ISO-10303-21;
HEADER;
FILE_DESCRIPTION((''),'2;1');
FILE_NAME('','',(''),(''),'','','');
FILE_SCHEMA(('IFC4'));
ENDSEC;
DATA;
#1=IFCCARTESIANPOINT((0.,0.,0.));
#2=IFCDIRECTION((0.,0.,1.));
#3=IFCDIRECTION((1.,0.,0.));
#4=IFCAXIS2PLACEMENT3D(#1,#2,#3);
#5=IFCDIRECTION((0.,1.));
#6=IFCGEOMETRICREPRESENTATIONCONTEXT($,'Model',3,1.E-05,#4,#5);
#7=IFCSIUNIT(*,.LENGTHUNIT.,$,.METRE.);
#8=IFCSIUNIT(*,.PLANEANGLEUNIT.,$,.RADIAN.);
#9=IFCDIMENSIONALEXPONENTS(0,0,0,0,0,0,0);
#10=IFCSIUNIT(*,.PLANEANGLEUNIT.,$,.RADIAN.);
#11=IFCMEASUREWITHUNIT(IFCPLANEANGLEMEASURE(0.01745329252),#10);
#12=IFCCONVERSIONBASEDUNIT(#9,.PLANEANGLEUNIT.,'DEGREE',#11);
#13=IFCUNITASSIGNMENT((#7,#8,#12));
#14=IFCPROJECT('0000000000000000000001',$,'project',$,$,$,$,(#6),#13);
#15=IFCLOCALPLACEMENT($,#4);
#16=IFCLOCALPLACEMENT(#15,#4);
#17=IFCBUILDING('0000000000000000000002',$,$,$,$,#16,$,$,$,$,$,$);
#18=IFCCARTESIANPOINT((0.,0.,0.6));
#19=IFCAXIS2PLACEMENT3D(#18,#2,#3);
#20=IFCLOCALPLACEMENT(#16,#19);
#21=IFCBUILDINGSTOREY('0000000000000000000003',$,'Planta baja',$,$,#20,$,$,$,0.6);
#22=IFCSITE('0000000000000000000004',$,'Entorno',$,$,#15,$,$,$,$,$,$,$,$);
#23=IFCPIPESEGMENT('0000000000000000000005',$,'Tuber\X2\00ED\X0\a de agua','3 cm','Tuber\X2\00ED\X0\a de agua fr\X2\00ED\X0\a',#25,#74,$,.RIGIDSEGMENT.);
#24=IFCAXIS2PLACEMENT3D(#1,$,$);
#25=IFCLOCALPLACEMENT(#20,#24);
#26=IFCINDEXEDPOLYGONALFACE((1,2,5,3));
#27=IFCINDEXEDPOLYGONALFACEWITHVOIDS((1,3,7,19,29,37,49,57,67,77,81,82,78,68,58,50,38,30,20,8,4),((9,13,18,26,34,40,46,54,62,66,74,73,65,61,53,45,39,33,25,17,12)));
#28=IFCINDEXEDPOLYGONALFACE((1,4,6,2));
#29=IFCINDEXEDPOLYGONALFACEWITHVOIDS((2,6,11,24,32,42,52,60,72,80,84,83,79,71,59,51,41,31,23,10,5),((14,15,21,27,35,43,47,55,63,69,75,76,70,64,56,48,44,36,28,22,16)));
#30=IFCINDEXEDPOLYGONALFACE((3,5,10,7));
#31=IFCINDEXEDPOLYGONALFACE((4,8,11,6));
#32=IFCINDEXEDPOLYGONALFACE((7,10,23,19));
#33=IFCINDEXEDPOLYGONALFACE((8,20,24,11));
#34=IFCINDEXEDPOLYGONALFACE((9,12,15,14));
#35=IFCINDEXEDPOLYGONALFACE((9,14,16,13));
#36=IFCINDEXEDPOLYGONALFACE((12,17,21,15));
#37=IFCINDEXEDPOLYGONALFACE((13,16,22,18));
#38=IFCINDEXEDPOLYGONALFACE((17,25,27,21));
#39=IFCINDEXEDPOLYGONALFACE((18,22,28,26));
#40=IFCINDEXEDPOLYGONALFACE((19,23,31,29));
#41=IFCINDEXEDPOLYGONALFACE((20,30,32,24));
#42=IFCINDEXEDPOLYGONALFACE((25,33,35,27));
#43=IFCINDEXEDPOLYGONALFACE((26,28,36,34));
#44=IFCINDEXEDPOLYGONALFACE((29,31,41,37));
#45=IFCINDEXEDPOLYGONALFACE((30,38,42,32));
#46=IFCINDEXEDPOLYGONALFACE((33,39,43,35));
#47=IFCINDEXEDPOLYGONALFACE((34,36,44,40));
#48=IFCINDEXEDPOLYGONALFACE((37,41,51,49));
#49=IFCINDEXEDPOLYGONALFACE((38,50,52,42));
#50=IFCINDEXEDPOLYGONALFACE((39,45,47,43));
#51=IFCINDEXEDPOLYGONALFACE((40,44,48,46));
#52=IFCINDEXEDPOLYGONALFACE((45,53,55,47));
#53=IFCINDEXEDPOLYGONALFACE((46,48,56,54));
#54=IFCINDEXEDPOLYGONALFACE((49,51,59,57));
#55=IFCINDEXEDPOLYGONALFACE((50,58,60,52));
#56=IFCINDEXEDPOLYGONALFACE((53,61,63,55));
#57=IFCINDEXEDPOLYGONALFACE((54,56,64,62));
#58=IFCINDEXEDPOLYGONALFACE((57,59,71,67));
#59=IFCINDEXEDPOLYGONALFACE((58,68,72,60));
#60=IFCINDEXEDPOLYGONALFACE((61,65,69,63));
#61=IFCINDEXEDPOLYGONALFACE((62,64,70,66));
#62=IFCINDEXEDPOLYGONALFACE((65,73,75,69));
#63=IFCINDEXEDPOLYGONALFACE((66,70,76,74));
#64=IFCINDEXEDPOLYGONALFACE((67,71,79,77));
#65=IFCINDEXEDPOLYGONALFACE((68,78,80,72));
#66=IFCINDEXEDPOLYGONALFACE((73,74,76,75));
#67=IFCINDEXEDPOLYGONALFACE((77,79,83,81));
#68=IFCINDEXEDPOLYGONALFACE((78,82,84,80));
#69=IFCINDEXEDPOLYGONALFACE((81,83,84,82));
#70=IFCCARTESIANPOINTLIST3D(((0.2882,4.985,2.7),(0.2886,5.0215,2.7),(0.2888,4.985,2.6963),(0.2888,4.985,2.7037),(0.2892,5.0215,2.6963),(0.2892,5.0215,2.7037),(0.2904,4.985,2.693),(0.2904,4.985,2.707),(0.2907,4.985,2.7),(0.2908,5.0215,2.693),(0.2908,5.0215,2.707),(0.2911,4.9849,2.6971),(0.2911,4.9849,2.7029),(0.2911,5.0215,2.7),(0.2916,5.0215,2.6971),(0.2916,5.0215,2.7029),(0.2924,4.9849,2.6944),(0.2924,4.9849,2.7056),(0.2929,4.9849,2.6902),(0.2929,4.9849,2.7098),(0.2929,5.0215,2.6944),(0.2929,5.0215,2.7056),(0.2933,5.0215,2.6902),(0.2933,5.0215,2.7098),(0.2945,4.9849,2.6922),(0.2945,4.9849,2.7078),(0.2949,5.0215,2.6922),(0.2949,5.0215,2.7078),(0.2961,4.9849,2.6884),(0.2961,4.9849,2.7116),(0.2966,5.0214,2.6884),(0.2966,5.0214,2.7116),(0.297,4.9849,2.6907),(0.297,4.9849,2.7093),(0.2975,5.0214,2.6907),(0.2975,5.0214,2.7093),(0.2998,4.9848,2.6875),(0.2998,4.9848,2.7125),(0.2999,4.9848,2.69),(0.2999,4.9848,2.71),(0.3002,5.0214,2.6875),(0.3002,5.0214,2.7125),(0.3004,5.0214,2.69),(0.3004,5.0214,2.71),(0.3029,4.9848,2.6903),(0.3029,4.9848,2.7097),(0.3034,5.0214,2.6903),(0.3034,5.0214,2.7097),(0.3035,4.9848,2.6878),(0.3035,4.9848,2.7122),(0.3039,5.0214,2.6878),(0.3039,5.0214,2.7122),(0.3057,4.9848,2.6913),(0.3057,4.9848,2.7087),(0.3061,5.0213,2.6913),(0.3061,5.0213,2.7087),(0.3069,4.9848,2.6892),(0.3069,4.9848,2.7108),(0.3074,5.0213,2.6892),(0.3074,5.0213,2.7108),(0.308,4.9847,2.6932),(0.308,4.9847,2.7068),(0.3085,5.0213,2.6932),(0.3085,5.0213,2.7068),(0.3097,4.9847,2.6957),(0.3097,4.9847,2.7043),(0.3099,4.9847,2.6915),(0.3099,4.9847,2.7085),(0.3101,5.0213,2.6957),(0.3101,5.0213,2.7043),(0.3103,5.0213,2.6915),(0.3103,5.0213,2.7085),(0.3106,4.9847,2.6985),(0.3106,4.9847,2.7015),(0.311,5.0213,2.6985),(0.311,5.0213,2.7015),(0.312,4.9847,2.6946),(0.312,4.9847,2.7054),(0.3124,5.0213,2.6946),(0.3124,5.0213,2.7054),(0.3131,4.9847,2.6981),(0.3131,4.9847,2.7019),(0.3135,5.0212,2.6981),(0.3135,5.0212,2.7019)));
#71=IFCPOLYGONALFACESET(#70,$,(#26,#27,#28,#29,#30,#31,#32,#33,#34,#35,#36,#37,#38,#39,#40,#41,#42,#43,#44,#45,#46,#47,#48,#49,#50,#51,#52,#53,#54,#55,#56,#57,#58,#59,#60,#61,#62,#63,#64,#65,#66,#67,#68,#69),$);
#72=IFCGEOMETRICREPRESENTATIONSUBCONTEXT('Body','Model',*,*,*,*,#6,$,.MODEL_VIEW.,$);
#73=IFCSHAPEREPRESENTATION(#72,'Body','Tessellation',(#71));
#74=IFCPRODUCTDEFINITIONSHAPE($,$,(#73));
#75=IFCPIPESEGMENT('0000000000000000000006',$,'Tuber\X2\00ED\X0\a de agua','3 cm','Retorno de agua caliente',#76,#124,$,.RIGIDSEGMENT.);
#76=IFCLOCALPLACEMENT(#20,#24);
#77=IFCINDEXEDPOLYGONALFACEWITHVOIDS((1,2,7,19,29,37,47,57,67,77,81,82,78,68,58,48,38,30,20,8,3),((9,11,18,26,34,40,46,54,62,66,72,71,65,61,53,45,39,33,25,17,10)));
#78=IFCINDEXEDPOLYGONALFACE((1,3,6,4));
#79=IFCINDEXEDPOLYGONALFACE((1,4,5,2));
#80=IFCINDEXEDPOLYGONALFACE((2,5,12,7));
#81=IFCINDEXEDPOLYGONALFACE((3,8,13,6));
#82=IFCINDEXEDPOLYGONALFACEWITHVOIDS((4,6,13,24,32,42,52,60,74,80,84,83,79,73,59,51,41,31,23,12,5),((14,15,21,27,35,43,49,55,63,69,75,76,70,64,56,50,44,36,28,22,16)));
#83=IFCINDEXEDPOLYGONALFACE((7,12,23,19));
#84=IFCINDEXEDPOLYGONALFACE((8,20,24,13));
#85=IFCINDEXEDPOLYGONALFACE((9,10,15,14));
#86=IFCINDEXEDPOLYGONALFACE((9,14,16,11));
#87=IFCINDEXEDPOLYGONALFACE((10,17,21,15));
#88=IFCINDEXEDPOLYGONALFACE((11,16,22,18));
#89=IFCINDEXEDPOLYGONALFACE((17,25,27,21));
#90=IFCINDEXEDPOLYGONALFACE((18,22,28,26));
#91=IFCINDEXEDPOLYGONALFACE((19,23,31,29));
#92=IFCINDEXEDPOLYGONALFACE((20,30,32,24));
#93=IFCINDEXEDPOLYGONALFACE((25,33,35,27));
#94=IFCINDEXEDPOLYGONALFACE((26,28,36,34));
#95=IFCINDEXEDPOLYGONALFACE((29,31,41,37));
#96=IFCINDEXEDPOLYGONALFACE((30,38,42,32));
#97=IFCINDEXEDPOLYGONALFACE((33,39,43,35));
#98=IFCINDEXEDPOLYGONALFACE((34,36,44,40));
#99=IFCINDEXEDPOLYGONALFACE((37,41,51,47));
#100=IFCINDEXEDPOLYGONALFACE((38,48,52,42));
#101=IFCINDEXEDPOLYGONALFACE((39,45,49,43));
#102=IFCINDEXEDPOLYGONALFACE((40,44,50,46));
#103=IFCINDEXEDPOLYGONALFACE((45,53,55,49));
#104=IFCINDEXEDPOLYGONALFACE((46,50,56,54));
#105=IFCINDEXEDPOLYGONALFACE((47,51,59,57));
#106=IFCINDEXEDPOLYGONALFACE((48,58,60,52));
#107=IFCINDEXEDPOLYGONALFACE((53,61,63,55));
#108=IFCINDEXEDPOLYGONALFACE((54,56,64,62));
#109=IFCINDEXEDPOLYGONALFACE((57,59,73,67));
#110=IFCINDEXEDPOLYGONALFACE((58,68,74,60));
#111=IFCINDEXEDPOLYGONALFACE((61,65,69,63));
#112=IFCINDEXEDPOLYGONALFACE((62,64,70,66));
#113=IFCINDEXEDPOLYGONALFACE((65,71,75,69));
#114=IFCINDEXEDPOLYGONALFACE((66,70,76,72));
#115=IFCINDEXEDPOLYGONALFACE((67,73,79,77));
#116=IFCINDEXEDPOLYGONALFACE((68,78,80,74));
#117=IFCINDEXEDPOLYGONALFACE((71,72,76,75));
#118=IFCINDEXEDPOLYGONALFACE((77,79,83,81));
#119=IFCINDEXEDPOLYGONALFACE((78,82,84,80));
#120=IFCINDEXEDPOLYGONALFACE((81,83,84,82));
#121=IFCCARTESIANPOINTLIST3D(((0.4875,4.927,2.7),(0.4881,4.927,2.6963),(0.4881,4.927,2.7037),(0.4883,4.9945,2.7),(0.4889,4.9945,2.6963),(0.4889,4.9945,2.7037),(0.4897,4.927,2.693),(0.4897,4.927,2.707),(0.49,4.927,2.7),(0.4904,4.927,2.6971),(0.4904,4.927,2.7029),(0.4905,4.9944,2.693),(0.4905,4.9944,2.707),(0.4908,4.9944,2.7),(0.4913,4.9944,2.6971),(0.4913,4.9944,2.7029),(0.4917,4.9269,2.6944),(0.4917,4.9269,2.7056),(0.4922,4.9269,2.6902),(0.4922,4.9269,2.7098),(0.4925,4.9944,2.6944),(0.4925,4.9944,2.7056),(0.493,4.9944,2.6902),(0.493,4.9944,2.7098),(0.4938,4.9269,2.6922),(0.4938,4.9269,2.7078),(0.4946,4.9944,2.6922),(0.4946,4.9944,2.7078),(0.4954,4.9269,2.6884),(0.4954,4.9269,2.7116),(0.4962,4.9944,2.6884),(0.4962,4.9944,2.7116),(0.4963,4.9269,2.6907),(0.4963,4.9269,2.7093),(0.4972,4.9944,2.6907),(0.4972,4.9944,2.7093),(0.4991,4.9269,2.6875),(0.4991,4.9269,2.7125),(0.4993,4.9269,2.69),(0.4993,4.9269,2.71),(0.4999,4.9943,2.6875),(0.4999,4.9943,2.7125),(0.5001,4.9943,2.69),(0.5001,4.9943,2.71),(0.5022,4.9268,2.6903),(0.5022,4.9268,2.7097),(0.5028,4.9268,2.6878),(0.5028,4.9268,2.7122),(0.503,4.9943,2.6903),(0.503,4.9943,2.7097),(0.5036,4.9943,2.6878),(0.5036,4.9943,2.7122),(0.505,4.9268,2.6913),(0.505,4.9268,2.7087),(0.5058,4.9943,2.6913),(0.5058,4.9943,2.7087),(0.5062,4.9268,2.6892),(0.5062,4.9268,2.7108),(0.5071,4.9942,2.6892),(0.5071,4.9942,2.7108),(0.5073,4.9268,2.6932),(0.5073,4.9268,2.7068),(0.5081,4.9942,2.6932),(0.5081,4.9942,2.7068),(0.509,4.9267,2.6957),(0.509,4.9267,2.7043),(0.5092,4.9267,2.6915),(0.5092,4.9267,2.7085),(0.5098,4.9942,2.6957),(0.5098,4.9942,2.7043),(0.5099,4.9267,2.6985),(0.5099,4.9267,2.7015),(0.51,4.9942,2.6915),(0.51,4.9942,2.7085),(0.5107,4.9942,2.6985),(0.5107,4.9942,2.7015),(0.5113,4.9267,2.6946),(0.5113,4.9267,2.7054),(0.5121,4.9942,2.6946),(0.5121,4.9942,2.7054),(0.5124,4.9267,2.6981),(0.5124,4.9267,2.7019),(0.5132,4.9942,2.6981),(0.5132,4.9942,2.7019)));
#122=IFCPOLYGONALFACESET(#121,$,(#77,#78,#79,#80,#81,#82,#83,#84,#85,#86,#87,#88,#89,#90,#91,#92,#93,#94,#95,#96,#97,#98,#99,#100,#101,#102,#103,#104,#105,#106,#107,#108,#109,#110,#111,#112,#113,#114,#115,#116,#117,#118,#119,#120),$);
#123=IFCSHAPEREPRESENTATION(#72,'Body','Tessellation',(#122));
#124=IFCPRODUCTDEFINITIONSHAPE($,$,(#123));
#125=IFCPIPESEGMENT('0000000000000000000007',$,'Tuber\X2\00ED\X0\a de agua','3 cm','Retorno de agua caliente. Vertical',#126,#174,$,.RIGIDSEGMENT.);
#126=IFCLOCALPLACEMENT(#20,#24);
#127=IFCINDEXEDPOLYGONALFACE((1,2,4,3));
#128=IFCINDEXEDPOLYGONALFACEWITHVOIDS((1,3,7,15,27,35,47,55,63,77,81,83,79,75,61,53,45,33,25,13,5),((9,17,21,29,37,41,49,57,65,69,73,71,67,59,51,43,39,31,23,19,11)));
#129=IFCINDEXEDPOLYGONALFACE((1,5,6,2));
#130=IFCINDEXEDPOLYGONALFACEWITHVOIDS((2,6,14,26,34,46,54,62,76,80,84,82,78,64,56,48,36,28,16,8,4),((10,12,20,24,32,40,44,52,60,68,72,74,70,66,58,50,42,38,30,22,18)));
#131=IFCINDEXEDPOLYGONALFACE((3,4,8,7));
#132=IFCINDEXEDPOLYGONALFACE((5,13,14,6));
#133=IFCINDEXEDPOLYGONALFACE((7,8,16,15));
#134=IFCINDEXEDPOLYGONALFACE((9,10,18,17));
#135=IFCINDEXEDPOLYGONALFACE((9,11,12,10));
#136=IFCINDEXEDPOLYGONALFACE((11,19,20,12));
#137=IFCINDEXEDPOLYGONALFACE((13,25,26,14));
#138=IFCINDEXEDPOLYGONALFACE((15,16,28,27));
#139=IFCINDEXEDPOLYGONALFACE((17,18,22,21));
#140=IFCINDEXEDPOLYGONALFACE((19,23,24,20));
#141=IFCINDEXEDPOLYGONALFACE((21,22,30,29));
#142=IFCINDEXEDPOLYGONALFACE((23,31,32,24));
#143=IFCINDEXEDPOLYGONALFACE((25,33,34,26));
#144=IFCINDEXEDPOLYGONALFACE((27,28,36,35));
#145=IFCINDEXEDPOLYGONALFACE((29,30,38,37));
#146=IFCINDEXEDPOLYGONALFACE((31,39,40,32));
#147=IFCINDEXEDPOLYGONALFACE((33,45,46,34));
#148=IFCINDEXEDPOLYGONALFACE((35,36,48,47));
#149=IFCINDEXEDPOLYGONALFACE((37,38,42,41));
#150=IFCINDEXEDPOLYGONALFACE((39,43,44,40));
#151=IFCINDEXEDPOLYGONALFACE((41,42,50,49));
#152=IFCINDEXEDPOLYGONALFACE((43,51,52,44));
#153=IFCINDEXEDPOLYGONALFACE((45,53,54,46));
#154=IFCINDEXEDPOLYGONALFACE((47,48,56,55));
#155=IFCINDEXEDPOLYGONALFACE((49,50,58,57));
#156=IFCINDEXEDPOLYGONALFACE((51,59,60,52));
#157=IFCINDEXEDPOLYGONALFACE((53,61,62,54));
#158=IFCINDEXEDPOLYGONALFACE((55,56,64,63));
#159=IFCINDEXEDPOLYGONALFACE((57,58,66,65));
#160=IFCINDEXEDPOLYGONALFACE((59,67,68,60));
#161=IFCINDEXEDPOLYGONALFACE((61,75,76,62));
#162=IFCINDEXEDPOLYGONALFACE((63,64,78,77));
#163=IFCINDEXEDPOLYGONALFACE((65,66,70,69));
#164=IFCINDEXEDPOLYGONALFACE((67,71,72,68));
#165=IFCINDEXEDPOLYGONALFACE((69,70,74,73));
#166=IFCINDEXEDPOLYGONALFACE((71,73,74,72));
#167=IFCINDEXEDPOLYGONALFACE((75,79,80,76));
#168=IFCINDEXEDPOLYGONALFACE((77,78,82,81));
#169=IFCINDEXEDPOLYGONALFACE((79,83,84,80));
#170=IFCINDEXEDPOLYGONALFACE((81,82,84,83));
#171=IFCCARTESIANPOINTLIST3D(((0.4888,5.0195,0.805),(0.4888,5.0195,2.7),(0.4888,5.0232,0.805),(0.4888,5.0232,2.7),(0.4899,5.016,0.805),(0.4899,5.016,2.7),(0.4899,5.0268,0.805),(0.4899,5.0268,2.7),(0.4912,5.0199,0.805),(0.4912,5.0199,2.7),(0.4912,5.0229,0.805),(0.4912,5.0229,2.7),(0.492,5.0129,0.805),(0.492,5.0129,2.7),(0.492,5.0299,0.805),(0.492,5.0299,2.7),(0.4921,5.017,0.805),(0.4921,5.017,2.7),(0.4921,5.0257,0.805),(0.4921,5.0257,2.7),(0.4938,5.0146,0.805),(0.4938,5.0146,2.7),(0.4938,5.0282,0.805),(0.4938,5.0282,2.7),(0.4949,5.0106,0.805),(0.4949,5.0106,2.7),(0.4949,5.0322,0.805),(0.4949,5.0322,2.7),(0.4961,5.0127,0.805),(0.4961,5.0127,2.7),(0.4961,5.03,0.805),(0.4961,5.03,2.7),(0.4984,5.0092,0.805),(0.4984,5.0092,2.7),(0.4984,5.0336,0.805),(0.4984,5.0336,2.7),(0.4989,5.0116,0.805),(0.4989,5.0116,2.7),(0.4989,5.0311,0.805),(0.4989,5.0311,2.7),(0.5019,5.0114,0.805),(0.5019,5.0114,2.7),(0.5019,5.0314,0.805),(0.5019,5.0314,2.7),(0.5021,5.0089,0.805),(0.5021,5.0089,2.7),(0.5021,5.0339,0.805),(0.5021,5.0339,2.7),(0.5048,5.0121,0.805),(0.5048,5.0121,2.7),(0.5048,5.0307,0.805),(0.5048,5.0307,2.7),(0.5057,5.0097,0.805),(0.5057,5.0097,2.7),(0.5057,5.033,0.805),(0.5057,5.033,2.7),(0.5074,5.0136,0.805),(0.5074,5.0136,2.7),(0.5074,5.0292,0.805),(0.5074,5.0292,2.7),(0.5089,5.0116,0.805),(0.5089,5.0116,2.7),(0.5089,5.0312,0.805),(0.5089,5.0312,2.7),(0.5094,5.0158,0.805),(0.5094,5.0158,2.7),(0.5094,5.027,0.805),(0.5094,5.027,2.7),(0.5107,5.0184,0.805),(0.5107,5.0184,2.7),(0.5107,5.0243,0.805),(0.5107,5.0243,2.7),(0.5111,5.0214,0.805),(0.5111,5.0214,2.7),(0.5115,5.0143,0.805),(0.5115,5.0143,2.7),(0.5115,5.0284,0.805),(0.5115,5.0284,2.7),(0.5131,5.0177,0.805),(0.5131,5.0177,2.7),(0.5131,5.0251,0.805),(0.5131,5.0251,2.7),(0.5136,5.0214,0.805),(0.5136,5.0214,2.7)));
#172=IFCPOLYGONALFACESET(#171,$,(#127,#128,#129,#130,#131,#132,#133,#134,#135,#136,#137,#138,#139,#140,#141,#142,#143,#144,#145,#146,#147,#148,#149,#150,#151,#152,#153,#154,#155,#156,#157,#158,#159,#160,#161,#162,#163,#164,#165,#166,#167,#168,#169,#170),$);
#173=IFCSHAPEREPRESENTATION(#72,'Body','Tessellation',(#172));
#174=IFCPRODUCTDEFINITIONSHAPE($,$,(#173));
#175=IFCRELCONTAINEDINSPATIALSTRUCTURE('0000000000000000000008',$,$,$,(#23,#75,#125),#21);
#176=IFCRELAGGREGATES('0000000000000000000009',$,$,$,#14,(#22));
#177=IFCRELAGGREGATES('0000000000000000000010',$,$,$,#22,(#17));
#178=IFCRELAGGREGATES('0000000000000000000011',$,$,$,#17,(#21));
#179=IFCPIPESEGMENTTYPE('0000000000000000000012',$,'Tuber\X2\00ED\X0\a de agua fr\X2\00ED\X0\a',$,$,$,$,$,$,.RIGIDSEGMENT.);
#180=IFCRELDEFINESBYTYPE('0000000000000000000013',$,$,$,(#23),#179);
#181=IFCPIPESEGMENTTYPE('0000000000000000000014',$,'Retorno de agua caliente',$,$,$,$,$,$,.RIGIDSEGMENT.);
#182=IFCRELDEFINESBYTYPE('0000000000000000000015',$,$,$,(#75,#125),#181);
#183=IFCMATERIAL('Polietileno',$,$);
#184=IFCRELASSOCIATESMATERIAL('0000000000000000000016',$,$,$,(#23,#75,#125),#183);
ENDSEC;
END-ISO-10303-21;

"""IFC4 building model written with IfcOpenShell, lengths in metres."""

from ifc_helpers import new_model, entity, si_unit, converted_unit, direction, frame, origin_with_axes, origin_2d_with_axis, place, context, subcontext, project, spatial, hollow_circle, extrude, material, type_object, element, save


model = new_model("IFC4")

# Units and contexts
model_context = context("Model", 3, precision=1e-05, world=origin_with_axes(), true_north=direction((0.0, 1.0)))
body_context = subcontext(model_context, "Body", "Model", "MODEL_VIEW")
ifc_project = project(units=[si_unit("LENGTHUNIT", "METRE"), si_unit("PLANEANGLEUNIT", "RADIAN"), converted_unit("PLANEANGLEUNIT", "DEGREE", entity("IfcPlaneAngleMeasure", 0.01745329252), si_unit("PLANEANGLEUNIT", "RADIAN"), dimensions=[0, 0, 0, 0, 0, 0, 0])], contexts=[model_context])

# Site, building, storey
site_placement = place(None, origin_with_axes())
site = spatial("IfcSite", under=ifc_project, at=site_placement, Name="Entorno")
building_placement = place(site_placement, origin_with_axes())
building = spatial("IfcBuilding", under=site, at=building_placement)
storey_placement = place(building_placement, frame((0.0, 0.0, 0.6), z_axis=(0.0, 0.0, 1.0), x_axis=(1.0, 0.0, 0.0)))
storey = spatial("IfcBuildingStorey", under=building, at=storey_placement, Name="Planta baja", Elevation=0.6)

# Pipe segments
ifc_material_1 = material(Name="Polietileno")
pipe_segment_type_1 = type_object("IfcPipeSegmentType", Name="Tubería de agua fría", PredefinedType="RIGIDSEGMENT")
pipe_segment_1_placement = place(storey_placement, frame((0.3007, 4.9848, 2.7), z_axis=(0.012002, 0.999928, 0.0), x_axis=(-0.999928, 0.012002, 0.0)))
element("IfcPipeSegment", 1, at=pipe_segment_1_placement, inside=storey, type_object=pipe_segment_type_1, material=ifc_material_1, Name="Tubería de agua", Description="3 cm", ObjectType="Tubería de agua fría", PredefinedType="RIGIDSEGMENT", context=body_context, shape_type="SweptSolid", body=[
    extrude(hollow_circle(Radius=0.0125, WallThickness=0.0025, at=origin_2d_with_axis()), origin_with_axes(), (0.0, 0.0, 1.0), 0.0366),
])
pipe_segment_type_2 = type_object("IfcPipeSegmentType", Name="Retorno de agua caliente", PredefinedType="RIGIDSEGMENT")
pipe_segment_2_placement = place(storey_placement, frame((0.5, 4.9268, 2.7), z_axis=(0.012002, 0.999928, 0.0), x_axis=(-0.999928, 0.012002, 0.0)))
element("IfcPipeSegment", 2, at=pipe_segment_2_placement, inside=storey, type_object=pipe_segment_type_2, material=ifc_material_1, Name="Tubería de agua", Description="3 cm", ObjectType="Retorno de agua caliente", PredefinedType="RIGIDSEGMENT", context=body_context, shape_type="SweptSolid", body=[
    extrude(hollow_circle(Radius=0.0125, WallThickness=0.0025, at=origin_2d_with_axis()), origin_with_axes(), (0.0, 0.0, 1.0), 0.0675),
])
pipe_segment_3_placement = place(storey_placement, frame((0.5011, 5.0214, 2.7), z_axis=(0.0, 0.0, -1.0), x_axis=(1.0, 0.0, 0.0)))
element("IfcPipeSegment", 3, at=pipe_segment_3_placement, inside=storey, type_object=pipe_segment_type_2, material=ifc_material_1, Name="Tubería de agua", Description="3 cm", ObjectType="Retorno de agua caliente. Vertical", PredefinedType="RIGIDSEGMENT", context=body_context, shape_type="SweptSolid", body=[
    extrude(hollow_circle(Radius=0.0125, WallThickness=0.0025, at=origin_2d_with_axis()), origin_with_axes(), (0.0, 0.0, 1.0), 1.895),
])

save(model, "model.ifc")
